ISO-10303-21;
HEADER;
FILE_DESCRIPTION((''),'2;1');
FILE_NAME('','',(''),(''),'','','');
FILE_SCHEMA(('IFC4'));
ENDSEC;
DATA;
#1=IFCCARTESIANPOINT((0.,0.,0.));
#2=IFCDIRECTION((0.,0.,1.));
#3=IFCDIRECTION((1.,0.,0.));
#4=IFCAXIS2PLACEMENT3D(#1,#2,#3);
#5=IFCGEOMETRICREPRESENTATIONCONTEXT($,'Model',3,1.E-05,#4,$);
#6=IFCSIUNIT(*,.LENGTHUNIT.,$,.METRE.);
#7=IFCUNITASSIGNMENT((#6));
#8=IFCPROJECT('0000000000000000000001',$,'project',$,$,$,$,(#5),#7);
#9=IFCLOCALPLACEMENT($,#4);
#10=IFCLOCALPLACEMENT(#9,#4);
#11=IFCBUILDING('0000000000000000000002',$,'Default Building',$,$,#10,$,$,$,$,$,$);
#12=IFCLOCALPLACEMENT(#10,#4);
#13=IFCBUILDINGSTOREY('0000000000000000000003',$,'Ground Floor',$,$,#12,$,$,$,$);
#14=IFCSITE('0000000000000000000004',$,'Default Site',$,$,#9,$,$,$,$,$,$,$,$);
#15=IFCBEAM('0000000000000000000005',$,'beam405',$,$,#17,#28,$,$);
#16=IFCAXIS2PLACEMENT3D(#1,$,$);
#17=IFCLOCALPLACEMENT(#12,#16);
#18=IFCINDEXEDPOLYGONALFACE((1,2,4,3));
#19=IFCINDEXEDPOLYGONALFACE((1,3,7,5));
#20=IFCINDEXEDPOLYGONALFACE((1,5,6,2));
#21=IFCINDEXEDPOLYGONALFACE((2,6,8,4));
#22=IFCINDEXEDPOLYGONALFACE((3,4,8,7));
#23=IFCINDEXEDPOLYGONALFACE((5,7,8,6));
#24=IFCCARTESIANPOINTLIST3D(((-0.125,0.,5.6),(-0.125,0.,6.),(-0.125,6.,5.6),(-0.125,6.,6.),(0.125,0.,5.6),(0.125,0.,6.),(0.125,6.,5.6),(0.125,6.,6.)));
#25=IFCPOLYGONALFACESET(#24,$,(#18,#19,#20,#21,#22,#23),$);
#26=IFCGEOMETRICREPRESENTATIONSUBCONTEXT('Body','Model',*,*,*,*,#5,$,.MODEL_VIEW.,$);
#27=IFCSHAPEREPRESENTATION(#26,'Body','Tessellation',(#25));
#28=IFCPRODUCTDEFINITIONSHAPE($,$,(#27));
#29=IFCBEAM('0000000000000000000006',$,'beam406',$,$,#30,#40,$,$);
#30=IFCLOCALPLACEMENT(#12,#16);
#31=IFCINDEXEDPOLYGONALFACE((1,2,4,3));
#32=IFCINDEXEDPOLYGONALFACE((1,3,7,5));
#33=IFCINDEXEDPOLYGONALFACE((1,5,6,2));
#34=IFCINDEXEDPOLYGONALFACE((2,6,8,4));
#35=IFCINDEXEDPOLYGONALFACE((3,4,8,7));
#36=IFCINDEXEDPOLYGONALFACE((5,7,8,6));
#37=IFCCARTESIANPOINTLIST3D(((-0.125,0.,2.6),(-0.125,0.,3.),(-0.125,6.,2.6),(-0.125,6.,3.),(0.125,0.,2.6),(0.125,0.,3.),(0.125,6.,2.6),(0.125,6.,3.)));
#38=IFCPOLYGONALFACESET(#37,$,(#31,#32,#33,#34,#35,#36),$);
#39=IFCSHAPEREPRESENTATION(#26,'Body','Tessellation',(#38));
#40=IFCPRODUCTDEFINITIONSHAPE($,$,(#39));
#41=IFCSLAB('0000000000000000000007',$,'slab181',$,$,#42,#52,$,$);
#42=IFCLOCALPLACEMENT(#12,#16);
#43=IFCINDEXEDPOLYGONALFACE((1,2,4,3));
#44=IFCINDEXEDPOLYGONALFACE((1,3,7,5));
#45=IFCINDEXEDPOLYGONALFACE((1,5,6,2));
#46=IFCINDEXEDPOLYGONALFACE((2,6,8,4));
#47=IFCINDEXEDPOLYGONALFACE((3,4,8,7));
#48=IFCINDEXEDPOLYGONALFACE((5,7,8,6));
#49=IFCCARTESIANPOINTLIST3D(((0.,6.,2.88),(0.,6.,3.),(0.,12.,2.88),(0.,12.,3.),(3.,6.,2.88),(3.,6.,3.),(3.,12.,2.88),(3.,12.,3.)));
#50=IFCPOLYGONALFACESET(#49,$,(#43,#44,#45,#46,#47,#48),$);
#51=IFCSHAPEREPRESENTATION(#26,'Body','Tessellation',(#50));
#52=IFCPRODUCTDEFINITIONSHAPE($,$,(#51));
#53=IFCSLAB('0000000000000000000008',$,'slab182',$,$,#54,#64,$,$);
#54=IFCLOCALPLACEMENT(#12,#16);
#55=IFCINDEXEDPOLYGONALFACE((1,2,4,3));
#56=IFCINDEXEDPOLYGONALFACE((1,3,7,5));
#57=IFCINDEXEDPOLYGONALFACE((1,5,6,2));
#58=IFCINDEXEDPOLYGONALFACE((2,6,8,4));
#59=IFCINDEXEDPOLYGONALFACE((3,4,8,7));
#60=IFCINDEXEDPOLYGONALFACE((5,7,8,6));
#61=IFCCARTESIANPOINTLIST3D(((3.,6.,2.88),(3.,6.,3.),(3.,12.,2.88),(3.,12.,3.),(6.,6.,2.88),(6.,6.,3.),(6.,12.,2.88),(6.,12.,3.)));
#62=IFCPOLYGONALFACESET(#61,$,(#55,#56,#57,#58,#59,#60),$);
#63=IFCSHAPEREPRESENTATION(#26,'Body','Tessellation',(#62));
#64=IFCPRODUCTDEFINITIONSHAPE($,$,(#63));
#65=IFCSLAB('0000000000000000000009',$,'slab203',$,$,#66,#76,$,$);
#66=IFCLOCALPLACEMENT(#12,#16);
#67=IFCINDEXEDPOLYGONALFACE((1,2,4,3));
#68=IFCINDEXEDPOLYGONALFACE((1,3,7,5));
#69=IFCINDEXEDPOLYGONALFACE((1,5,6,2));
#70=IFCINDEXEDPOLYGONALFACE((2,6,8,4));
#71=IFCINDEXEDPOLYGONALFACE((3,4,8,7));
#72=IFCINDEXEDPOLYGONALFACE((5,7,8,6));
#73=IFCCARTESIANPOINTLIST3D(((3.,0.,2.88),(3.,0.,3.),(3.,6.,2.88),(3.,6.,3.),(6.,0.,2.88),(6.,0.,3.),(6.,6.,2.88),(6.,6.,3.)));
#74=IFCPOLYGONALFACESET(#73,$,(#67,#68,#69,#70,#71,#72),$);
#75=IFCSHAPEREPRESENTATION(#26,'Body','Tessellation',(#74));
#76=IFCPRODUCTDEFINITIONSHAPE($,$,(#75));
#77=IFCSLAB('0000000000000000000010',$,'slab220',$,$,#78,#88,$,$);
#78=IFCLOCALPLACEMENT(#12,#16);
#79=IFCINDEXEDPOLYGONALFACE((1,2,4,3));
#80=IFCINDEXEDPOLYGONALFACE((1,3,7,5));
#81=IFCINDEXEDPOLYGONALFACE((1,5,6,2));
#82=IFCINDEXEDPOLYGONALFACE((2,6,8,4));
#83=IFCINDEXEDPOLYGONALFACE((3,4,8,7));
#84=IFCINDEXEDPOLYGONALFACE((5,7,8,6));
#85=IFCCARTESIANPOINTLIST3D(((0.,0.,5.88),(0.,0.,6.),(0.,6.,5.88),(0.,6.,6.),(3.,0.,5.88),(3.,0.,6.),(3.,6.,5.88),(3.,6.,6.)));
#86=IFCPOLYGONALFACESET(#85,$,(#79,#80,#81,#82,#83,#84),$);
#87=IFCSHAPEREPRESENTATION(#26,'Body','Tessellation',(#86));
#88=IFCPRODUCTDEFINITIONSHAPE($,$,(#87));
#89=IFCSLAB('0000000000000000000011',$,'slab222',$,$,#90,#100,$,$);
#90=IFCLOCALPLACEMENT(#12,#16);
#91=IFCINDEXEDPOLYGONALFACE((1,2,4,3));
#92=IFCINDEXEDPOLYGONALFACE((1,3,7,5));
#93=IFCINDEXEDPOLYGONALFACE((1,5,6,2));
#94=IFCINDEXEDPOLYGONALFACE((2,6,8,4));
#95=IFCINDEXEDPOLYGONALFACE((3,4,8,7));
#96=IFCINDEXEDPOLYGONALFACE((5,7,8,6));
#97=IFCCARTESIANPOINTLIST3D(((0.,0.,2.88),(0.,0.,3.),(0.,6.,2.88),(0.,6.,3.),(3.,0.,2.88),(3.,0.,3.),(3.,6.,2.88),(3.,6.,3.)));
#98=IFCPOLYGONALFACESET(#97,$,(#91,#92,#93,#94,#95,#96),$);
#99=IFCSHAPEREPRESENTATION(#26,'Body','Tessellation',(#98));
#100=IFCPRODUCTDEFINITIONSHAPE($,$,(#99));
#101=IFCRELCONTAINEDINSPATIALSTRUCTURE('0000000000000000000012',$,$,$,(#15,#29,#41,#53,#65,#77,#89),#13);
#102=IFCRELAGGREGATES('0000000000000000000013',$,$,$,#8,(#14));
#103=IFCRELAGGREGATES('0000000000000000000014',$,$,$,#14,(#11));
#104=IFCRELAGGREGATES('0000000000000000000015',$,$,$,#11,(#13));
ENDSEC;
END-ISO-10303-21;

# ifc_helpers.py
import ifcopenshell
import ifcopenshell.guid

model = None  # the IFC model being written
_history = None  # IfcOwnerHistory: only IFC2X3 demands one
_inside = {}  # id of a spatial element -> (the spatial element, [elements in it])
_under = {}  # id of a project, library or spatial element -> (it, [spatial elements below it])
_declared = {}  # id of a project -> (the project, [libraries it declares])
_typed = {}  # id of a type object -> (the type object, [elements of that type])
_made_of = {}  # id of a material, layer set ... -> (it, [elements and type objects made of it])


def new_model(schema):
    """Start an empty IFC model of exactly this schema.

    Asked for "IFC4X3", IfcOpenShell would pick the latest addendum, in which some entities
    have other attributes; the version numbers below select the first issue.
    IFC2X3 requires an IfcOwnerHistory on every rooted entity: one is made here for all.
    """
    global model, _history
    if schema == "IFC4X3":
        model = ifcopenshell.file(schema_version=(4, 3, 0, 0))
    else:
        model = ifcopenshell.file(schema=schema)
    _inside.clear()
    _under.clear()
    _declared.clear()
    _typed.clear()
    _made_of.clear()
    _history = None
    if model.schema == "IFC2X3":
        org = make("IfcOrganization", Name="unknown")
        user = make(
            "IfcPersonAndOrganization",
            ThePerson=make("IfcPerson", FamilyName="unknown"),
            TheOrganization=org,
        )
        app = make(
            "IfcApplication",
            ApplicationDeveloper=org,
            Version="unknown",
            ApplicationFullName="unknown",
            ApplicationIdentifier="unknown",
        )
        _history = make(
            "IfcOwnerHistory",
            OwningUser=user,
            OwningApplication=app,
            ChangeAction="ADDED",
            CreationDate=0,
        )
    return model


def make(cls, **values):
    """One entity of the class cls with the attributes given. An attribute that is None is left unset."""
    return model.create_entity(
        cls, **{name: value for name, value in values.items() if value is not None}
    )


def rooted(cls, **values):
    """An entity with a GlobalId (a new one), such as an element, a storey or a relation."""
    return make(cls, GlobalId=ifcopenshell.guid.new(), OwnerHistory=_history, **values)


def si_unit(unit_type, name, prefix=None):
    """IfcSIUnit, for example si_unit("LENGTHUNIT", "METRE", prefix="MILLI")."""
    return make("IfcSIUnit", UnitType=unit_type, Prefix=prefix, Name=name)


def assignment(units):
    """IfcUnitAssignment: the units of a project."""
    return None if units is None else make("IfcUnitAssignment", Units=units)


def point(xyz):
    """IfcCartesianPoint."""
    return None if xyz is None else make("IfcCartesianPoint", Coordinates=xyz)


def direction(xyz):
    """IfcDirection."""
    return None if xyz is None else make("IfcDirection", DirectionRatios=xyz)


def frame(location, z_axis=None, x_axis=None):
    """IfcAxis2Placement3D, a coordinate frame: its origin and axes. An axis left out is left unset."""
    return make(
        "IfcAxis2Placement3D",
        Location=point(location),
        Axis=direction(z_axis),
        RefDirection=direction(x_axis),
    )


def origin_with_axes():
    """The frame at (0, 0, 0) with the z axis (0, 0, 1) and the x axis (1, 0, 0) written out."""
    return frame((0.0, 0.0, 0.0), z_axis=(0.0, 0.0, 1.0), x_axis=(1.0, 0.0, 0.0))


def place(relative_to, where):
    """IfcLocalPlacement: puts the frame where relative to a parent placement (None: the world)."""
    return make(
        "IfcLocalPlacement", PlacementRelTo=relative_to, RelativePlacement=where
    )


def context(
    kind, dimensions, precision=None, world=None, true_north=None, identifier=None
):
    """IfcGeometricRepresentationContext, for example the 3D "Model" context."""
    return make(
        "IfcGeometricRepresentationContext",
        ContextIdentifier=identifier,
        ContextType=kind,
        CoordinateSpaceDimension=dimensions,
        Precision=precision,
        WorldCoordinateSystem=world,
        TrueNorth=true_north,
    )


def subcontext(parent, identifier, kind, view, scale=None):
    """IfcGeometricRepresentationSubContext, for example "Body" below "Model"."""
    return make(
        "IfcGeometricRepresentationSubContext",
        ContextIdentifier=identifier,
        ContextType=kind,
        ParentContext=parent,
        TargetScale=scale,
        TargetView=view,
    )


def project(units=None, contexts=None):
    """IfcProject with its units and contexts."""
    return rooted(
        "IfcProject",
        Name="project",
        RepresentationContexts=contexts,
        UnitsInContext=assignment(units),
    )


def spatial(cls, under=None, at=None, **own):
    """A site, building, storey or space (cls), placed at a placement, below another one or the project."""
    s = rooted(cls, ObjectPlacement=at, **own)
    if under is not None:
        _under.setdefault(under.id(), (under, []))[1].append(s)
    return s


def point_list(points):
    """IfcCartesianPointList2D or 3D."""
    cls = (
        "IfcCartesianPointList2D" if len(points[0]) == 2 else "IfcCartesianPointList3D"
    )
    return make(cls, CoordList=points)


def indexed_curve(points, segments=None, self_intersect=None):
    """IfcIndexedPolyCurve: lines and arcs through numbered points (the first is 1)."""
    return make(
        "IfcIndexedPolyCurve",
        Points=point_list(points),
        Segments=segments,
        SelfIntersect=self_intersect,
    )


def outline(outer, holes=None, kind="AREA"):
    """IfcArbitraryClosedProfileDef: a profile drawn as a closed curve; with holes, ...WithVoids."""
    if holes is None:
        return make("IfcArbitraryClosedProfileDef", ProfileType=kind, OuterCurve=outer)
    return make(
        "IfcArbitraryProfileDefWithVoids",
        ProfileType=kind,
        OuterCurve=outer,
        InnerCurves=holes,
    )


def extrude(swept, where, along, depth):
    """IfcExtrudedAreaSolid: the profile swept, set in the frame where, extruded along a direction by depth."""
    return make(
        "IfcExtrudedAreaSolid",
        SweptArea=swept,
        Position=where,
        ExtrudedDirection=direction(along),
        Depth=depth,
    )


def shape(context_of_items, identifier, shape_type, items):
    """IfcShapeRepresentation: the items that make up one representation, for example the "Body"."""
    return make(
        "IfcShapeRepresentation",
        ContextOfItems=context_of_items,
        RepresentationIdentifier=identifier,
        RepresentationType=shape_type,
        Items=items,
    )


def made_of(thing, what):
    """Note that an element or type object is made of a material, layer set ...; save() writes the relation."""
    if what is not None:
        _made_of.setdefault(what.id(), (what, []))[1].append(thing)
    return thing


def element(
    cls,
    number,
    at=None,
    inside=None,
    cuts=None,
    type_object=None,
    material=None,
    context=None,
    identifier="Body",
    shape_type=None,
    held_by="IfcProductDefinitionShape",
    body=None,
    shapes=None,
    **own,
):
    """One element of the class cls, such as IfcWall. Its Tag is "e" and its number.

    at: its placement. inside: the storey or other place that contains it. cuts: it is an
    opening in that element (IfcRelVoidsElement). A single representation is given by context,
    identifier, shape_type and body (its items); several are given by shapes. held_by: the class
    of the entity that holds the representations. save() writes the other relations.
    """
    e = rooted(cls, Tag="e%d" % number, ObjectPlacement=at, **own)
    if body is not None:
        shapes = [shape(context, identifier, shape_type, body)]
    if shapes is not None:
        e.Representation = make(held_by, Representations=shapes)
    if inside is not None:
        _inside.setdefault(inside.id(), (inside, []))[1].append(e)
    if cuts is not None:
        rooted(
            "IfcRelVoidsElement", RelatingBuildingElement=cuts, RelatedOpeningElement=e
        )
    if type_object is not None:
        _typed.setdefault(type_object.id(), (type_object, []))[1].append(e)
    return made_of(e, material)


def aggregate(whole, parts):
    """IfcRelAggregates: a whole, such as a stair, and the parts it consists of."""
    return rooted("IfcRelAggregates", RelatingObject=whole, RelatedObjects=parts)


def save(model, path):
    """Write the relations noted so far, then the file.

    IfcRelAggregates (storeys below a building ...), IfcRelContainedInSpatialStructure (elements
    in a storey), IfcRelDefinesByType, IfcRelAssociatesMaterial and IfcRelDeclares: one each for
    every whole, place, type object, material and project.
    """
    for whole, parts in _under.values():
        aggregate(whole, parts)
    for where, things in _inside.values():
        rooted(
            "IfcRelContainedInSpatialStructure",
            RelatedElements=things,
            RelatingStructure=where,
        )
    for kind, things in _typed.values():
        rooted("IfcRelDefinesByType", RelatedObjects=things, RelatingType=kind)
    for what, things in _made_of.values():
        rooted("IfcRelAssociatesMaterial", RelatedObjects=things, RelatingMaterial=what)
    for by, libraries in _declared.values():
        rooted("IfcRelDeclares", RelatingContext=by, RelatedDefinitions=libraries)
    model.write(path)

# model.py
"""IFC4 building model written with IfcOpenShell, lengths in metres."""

from ifc_helpers import new_model, si_unit, frame, origin_with_axes, place, context, subcontext, project, spatial, indexed_curve, outline, extrude, element, save


model = new_model("IFC4")

# Units and contexts
model_context = context("Model", 3, precision=1e-05, world=origin_with_axes())
body_context = subcontext(model_context, "Body", "Model", "MODEL_VIEW")
ifc_project = project(units=[si_unit("LENGTHUNIT", "METRE")], contexts=[model_context])

# Site, building, storey
site_placement = place(None, origin_with_axes())
site = spatial("IfcSite", under=ifc_project, at=site_placement, Name="Default Site")
building_placement = place(site_placement, origin_with_axes())
building = spatial("IfcBuilding", under=site, at=building_placement, Name="Default Building")
storey_placement = place(building_placement, origin_with_axes())
storey = spatial("IfcBuildingStorey", under=building, at=storey_placement, Name="Ground Floor")

# Beams
for number, where, z_axis, x_axis, name in (
    (1, (-0.125, 6.0, 5.6), (0.0, 0.0, 1.0), (0.0, -1.0, 0.0), "beam405"),
    (2, (-0.125, 6.0, 2.6), (0.0, 0.0, 1.0), (0.0, -1.0, 0.0), "beam406"),
):
    element("IfcBeam", number, at=place(storey_placement, frame(where, z_axis=z_axis, x_axis=x_axis)), inside=storey, Name=name, context=body_context, shape_type="SweptSolid", body=[
        extrude(outline(indexed_curve([(0.0, 0.0), (0.0, 0.25), (6.0, 0.25), (6.0, 0.0), (0.0, 0.0)], self_intersect=False)), origin_with_axes(), (0.0, 0.0, 1.0), 0.4),
    ])

# Slabs
for number, where, z_axis, x_axis, name in (
    (3, (0.0, 6.0, 2.88), (0.0, 0.0, 1.0), (1.0, 0.0, 0.0), "slab181"),
    (4, (3.0, 6.0, 2.88), (0.0, 0.0, 1.0), (1.0, 0.0, 0.0), "slab182"),
    (5, (3.0, 0.0, 2.88), (0.0, 0.0, 1.0), (1.0, 0.0, 0.0), "slab203"),
    (6, (0.0, 0.0, 5.88), (0.0, 0.0, 1.0), (1.0, 0.0, 0.0), "slab220"),
    (7, (0.0, 0.0, 2.88), (0.0, 0.0, 1.0), (1.0, 0.0, 0.0), "slab222"),
):
    element("IfcSlab", number, at=place(storey_placement, frame(where, z_axis=z_axis, x_axis=x_axis)), inside=storey, Name=name, context=body_context, shape_type="SweptSolid", body=[
        extrude(outline(indexed_curve([(0.0, 0.0), (0.0, 6.0), (3.0, 6.0), (3.0, 0.0), (0.0, 0.0)], self_intersect=False)), origin_with_axes(), (0.0, 0.0, 1.0), 0.12),
    ])

save(model, "model.ifc")
